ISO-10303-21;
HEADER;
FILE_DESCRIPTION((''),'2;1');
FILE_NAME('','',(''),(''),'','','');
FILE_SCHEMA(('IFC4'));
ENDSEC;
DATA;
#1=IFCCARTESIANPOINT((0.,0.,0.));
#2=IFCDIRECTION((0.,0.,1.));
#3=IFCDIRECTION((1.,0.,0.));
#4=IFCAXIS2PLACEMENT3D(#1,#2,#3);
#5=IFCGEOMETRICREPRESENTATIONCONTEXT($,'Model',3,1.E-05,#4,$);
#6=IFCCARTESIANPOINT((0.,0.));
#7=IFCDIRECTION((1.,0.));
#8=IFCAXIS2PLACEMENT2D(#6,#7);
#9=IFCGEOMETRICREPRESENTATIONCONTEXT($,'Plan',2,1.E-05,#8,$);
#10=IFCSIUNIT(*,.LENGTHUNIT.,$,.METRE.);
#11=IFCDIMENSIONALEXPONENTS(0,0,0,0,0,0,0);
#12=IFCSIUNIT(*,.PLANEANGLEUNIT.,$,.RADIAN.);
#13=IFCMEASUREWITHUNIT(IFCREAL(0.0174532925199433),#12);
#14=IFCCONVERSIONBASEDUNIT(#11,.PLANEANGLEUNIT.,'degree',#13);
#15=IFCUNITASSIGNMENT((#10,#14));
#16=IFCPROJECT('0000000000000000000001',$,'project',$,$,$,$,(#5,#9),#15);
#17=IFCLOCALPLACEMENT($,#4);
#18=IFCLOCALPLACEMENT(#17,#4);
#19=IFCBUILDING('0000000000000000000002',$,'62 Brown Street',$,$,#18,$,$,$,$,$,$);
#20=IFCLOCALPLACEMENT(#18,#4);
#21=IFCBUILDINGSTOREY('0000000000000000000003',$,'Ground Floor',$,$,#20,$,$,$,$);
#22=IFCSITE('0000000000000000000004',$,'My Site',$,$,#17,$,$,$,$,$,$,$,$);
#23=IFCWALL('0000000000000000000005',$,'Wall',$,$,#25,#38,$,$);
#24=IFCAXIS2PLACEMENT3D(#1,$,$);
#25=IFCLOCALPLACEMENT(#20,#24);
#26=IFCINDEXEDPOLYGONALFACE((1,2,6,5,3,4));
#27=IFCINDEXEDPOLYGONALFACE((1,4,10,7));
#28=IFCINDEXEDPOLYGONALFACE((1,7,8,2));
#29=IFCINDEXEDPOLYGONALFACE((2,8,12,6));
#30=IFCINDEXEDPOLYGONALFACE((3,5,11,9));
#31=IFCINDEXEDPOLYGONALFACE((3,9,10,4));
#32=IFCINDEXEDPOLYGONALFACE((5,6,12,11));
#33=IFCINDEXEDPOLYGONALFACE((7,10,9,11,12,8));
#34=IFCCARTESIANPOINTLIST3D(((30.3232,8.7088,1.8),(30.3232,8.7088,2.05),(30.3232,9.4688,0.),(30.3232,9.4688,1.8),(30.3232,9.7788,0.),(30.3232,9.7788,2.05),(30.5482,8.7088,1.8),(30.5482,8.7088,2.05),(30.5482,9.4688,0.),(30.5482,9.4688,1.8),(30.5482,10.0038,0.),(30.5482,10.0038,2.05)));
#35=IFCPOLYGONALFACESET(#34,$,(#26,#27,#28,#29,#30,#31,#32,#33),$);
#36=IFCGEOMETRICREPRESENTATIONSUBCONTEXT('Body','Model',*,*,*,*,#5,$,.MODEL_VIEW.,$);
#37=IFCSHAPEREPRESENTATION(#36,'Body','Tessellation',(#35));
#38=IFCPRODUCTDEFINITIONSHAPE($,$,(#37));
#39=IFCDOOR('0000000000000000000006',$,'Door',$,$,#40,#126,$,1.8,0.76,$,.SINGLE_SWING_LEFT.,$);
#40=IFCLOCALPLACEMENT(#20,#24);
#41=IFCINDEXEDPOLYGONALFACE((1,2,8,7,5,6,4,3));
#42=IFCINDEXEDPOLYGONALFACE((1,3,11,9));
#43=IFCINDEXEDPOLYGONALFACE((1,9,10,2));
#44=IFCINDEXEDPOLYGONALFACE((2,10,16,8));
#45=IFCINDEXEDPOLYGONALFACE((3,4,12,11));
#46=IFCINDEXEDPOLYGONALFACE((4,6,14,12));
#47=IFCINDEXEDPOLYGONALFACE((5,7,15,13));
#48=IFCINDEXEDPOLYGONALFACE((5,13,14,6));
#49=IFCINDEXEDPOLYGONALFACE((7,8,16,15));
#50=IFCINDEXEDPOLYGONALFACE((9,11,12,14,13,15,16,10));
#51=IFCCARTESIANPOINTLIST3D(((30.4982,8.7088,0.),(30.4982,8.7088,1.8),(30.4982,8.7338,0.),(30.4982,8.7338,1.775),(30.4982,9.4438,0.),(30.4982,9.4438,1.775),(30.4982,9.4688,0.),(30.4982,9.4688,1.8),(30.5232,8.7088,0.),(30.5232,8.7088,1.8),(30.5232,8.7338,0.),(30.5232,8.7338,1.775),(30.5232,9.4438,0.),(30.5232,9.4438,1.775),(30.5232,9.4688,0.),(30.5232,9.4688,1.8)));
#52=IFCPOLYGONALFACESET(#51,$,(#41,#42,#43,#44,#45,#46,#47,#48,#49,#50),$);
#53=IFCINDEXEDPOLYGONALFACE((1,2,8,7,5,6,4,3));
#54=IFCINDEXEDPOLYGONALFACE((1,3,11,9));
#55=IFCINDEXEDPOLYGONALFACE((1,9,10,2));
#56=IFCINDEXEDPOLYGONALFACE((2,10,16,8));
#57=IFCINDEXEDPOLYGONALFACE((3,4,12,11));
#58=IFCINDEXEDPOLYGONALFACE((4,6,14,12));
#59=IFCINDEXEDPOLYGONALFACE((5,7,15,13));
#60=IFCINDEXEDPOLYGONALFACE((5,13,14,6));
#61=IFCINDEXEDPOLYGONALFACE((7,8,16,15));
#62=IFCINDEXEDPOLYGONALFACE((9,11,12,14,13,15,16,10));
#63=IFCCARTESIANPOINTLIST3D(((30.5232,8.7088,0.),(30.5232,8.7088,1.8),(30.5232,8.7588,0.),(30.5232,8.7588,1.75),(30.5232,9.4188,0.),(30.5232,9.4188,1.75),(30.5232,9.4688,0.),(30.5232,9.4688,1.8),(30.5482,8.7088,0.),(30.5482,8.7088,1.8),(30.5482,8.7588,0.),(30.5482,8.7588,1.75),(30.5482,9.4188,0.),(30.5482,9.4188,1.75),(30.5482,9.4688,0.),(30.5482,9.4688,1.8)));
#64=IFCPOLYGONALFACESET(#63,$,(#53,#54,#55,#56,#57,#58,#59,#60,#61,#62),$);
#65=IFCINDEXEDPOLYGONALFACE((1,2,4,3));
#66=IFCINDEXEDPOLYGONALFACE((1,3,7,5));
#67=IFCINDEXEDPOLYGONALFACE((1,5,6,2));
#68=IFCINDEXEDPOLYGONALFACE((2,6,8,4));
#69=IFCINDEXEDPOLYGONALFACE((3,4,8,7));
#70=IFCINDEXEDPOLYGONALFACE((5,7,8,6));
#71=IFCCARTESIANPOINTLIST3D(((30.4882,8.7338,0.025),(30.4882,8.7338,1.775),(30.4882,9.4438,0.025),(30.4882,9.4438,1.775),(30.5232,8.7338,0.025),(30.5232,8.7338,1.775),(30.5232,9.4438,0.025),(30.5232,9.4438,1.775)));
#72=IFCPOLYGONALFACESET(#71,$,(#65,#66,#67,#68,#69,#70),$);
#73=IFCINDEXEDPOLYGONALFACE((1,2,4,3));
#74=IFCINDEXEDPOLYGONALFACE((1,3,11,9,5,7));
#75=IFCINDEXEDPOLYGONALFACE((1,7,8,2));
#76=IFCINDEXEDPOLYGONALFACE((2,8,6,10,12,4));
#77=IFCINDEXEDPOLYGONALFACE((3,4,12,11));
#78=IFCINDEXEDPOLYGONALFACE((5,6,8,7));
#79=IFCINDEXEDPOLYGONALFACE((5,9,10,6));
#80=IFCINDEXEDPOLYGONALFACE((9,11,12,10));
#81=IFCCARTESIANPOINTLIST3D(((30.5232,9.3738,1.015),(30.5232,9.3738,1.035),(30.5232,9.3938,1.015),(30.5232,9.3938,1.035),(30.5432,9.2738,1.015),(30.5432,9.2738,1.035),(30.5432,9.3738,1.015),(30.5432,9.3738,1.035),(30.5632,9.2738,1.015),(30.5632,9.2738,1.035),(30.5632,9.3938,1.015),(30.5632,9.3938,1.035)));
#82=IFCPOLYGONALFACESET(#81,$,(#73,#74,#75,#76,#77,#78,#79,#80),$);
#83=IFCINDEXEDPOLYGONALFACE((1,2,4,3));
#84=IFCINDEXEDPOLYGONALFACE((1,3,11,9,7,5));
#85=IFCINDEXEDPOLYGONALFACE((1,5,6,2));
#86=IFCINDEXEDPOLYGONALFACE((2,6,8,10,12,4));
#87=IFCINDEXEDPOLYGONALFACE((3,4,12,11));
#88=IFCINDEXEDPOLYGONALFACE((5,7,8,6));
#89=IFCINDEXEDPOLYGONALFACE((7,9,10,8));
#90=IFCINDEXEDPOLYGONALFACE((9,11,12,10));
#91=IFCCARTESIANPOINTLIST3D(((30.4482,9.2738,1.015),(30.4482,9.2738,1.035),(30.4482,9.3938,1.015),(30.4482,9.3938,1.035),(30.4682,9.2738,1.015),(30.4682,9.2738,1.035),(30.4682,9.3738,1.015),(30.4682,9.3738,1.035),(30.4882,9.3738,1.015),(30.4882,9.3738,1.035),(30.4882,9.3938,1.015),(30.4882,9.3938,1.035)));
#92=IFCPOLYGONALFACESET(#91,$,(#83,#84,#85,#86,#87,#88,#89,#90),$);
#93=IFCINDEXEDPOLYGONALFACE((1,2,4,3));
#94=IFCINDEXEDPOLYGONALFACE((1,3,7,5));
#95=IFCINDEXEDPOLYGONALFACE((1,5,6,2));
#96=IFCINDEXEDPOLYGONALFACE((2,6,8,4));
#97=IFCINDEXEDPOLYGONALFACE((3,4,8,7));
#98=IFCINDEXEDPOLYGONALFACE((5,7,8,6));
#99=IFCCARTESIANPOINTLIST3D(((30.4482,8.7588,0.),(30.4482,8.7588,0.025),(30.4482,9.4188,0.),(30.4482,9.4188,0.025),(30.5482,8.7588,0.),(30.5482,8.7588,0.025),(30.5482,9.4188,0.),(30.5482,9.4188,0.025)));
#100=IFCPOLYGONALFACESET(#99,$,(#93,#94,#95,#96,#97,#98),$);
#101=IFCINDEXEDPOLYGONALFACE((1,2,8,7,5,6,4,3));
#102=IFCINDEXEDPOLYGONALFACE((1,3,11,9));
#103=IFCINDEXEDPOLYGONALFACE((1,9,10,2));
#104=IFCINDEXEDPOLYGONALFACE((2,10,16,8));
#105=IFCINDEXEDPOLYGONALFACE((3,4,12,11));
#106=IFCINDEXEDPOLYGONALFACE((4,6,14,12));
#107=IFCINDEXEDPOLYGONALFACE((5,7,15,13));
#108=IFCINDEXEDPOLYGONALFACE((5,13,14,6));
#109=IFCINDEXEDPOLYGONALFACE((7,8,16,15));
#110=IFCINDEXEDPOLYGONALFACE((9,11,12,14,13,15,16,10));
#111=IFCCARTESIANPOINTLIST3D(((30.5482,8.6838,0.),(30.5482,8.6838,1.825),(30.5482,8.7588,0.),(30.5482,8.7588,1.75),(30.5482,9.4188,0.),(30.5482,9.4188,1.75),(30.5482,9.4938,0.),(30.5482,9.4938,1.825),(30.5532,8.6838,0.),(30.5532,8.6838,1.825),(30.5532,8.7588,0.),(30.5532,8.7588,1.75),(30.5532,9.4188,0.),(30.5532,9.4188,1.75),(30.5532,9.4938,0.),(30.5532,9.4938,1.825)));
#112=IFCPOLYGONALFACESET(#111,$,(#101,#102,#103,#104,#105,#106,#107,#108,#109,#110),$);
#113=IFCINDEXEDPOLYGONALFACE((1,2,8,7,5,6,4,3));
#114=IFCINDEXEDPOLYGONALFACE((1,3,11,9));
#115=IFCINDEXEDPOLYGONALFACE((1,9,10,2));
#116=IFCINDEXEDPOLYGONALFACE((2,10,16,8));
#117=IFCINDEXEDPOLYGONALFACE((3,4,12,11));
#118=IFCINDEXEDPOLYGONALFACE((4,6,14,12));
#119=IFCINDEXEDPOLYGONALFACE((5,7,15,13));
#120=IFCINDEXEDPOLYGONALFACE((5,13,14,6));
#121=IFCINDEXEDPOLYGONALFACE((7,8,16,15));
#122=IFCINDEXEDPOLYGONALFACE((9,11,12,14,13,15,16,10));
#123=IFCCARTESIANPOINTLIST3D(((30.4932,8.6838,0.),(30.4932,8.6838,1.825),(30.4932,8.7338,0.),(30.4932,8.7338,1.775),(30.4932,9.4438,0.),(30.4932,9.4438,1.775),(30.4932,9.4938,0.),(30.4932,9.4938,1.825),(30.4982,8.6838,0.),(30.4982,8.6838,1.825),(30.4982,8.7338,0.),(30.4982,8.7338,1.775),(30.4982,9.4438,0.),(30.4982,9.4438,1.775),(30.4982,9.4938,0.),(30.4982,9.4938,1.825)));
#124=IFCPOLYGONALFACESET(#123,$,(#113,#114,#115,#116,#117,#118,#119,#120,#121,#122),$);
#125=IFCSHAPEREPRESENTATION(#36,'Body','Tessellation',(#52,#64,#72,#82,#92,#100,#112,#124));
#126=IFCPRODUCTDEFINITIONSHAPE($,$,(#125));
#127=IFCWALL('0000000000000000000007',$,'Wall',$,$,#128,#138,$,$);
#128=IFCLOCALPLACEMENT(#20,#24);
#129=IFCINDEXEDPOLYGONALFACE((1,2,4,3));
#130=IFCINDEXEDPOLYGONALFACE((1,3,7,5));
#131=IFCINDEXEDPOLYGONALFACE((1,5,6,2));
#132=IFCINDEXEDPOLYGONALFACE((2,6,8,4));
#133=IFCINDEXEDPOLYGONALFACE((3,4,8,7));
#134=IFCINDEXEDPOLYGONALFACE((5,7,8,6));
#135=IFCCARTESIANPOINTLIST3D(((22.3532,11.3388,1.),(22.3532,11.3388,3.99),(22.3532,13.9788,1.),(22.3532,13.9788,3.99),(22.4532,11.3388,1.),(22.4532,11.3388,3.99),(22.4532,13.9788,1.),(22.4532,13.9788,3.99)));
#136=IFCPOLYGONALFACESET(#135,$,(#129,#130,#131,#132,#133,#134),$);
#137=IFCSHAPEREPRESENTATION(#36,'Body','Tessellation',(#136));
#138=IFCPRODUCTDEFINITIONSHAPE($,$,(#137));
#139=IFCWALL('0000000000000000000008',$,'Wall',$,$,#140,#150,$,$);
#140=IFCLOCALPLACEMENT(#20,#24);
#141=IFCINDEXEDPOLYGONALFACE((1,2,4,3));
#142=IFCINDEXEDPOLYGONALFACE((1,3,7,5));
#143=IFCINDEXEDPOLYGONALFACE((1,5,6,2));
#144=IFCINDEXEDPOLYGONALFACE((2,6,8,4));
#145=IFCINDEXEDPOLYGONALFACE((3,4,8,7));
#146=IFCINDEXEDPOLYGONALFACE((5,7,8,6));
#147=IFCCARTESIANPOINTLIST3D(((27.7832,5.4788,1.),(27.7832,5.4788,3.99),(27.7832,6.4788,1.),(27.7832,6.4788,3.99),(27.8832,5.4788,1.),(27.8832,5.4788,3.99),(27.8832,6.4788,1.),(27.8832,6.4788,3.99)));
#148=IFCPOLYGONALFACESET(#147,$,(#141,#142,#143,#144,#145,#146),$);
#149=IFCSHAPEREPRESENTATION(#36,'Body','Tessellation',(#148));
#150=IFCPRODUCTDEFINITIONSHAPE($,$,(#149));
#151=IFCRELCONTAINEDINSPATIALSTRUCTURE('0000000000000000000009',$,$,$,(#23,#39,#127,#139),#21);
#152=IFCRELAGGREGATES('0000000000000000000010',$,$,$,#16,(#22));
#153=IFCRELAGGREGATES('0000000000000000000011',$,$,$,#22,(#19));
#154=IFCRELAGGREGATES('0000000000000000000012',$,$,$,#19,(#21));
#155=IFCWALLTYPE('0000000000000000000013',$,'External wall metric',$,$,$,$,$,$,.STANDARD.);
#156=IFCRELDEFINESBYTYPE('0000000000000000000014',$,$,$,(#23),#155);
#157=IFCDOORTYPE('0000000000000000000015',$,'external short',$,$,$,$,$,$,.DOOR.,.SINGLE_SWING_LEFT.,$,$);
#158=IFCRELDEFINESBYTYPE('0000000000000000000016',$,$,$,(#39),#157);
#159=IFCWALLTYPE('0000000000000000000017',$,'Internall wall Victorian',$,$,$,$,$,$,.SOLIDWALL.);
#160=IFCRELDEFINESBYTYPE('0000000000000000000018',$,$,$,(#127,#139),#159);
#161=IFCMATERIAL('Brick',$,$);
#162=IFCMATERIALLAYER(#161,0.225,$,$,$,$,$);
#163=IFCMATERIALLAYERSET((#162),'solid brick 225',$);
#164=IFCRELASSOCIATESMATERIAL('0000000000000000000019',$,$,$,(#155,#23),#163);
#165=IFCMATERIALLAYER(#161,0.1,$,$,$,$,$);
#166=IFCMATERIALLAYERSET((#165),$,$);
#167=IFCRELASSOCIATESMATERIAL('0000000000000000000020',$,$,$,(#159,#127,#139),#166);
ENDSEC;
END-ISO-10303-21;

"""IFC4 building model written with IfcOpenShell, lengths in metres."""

from ifc_helpers import new_model, entity, si_unit, converted_unit, frame, origin_with_axes, origin_2d_with_axis, place, context, subcontext, project, spatial, line, indexed_curve, outline, extrude, clip, halfspace, shape, source, transform, mapped, material, layer, layer_set, layer_usage, type_object, type_shapes, element, fill, save


model = new_model("IFC4")

# Units and contexts
model_context = context("Model", 3, precision=1e-05, world=origin_with_axes())
plan_context = context("Plan", 2, precision=1e-05, world=origin_2d_with_axis())
body_context_1 = subcontext(model_context, "Body", "Model", "MODEL_VIEW")
body_context_2 = subcontext(plan_context, "Body", "Plan", "PLAN_VIEW")
ifc_project = project(units=[si_unit("LENGTHUNIT", "METRE"), converted_unit("PLANEANGLEUNIT", "degree", entity("IfcReal", 0.0174532925199433), si_unit("PLANEANGLEUNIT", "RADIAN"), dimensions=[0, 0, 0, 0, 0, 0, 0])], contexts=[model_context, plan_context])

# Site, building, storey
site_placement = place(None, origin_with_axes())
site = spatial("IfcSite", under=ifc_project, at=site_placement, Name="My Site")
building_placement = place(site_placement, origin_with_axes())
building = spatial("IfcBuilding", under=site, at=building_placement, Name="62 Brown Street")
storey_placement = place(building_placement, origin_with_axes())
storey = spatial("IfcBuildingStorey", under=building, at=storey_placement, Name="Ground Floor")

# Shared definitions
ifc_material_1 = material(Name="Brick")

# Shared definitions
ifc_layer_1 = layer(ifc_material_1, 0.225)
ifc_layer_set_1 = layer_set([ifc_layer_1], Name="solid brick 225")
wall_type_1 = type_object("IfcWallType", Name="External wall metric", PredefinedType="STANDARD", material=ifc_layer_set_1)

# Wall, opening, door
ifc_layer_usage_1 = layer_usage(ifc_layer_set_1, "AXIS2", "POSITIVE", 0.0)
wall_1_placement = place(storey_placement, frame((30.5482, 8.7088, 0.0), z_axis=(0.0, 0.0, 1.0), x_axis=(0.0, 1.0, 0.0)))
wall_1 = element("IfcWall", 1, at=wall_1_placement, inside=storey, type_object=wall_type_1, material=ifc_layer_usage_1, Name="Wall", context=body_context_1, shape_type="Clipping", body=[
    clip(extrude(outline(indexed_curve([(0.0, 0.0), (0.0, 0.225), (1.295, 0.225), (1.295, 0.0), (0.0, 0.0)], self_intersect=False)), origin_with_axes(), (0.0, 0.0, 1.0), 2.05), halfspace(frame((1.295, 0.0, 0.0), z_axis=(0.450001, 0.450001, 0.0), x_axis=(-0.225, 0.225, 0.0)), False)),
])
shared_shape_1 = source(origin_with_axes(), body_context_1, "Body", "SweptSolid", [
    extrude(outline(indexed_curve([(0.0, 0.0), (0.76, 0.0), (0.76, 1.8), (0.0, 1.8)], segments=[line(1, 2, 3, 4, 1)])), frame((0.0, -0.1, 0.0), z_axis=(0.0, -1.0, 0.0), x_axis=(1.0, 0.0, 0.0)), (0.0, 0.0, -1.0), 0.425),
])
opening_placement = place(wall_1_placement, frame((0.0, 0.0, 0.0), z_axis=(0.0, 0.0, 1.0), x_axis=(1.0, 0.0, 0.0)))
opening = element("IfcOpeningElement", 2, at=opening_placement, cuts=wall_1, PredefinedType="OPENING", context=body_context_1, shape_type="MappedRepresentation", body=[
    mapped(shared_shape_1, transform((0.0, 0.0, 0.0), x_axis=(1.0, 0.0, 0.0), y_axis=(0.0, 1.0, 0.0), z_axis=(0.0, 0.0, 1.0), scale=1.0)),
])
door_type = type_object("IfcDoorType", Name="external short", OperationType="SINGLE_SWING_LEFT", PredefinedType="DOOR")
shared_shape_2 = source(origin_with_axes(), body_context_1, "Body", "SweptSolid", [
    extrude(outline(indexed_curve([(0.0, 0.0), (0.0, 1.8), (0.76, 1.8), (0.76, 0.0), (0.735, 0.0), (0.735, 1.775), (0.025, 1.775), (0.025, 0.0)], segments=[line(1, 2, 3, 4, 5, 6, 7, 8, 1)])), frame((0.0, 0.025, 0.0), z_axis=(0.0, -1.0, 0.0), x_axis=(1.0, 0.0, 0.0)), (0.0, 0.0, -1.0), 0.025),
    extrude(outline(indexed_curve([(0.0, 0.0), (0.0, 1.8), (0.76, 1.8), (0.76, 0.0), (0.71, 0.0), (0.71, 1.75), (0.05, 1.75), (0.05, 0.0)], segments=[line(1, 2, 3, 4, 5, 6, 7, 8, 1)])), frame((0.0, 0.0, 0.0), z_axis=(0.0, -1.0, 0.0), x_axis=(1.0, 0.0, 0.0)), (0.0, 0.0, -1.0), 0.025),
    extrude(outline(indexed_curve([(0.0, 0.0), (0.71, 0.0), (0.71, 0.035), (0.0, 0.035)], segments=[line(1, 2, 3, 4, 1)])), frame((0.025, 0.025, 0.025), z_axis=(0.0, 0.0, 1.0), x_axis=(1.0, 0.0, 0.0)), (0.0, 0.0, 1.0), 1.75),
    extrude(outline(indexed_curve([(0.0, 0.0), (0.0, -0.04), (-0.12, -0.04), (-0.12, -0.02), (-0.02, -0.02), (-0.02, 0.0)], segments=[line(1, 2, 3, 4, 5, 6, 1)])), frame((0.685, 0.025, 1.015), z_axis=(0.0, 0.0, 1.0), x_axis=(1.0, 0.0, 0.0)), (0.0, 0.0, 1.0), 0.02),
    extrude(outline(indexed_curve([(0.0, 0.0), (0.0, 0.04), (-0.12, 0.04), (-0.12, 0.02), (-0.02, 0.02), (-0.02, 0.0)], segments=[line(1, 2, 3, 4, 5, 6, 1)])), frame((0.685, 0.06, 1.015), z_axis=(0.0, 0.0, 1.0), x_axis=(1.0, 0.0, 0.0)), (0.0, 0.0, 1.0), 0.02),
    extrude(outline(indexed_curve([(0.0, 0.0), (0.66, 0.0), (0.66, 0.1), (0.0, 0.1)], segments=[line(1, 2, 3, 4, 1)])), frame((0.05, 0.0, 0.0), z_axis=(0.0, 0.0, 1.0), x_axis=(1.0, 0.0, 0.0)), (0.0, 0.0, 1.0), 0.025),
    extrude(outline(indexed_curve([(0.0, 0.0), (0.0, 1.825), (0.81, 1.825), (0.81, 0.0), (0.735, 0.0), (0.735, 1.75), (0.075, 1.75), (0.075, 0.0)], segments=[line(1, 2, 3, 4, 5, 6, 7, 8, 1)])), frame((-0.025, -0.005, 0.0), z_axis=(0.0, -1.0, 0.0), x_axis=(1.0, 0.0, 0.0)), (0.0, 0.0, -1.0), 0.005),
    extrude(outline(indexed_curve([(0.0, 0.0), (0.0, 1.825), (0.81, 1.825), (0.81, 0.0), (0.76, 0.0), (0.76, 1.775), (0.05, 1.775), (0.05, 0.0)], segments=[line(1, 2, 3, 4, 5, 6, 7, 8, 1)])), frame((-0.025, 0.05, 0.0), z_axis=(0.0, -1.0, 0.0), x_axis=(1.0, 0.0, 0.0)), (0.0, 0.0, -1.0), 0.005),
])
shared_shape_3 = source(origin_with_axes(), body_context_2, "Body", "Curve2D", [
    entity("IfcIndexedPolyCurve", entity("IfcCartesianPointList2D", [[0.0, 0.0], [0.0, 0.05], [0.025, 0.05], [0.025, 0.025], [0.05, 0.025], [0.05, 0.0]]), [entity("IfcLineIndex", [1, 2, 3, 4, 5, 6, 1])]),
    entity("IfcIndexedPolyCurve", entity("IfcCartesianPointList2D", [[0.76, 0.0], [0.76, 0.05], [0.735, 0.05], [0.735, 0.025], [0.71, 0.025], [0.71, 0.0]]), [entity("IfcLineIndex", [1, 2, 3, 4, 5, 6, 1])]),
    entity("IfcTrimmedCurve", entity("IfcEllipse", entity("IfcAxis2Placement2D", entity("IfcCartesianPoint", [0.06, 0.05]), entity("IfcDirection", [1.0, 0.0])), 0.675, 0.71), [entity("IfcCartesianPoint", [0.735, 0.05])], [entity("IfcCartesianPoint", [0.06, 0.76])], True, "CARTESIAN"),
    entity("IfcIndexedPolyCurve", entity("IfcCartesianPointList2D", [[0.025, 0.05], [0.06, 0.05], [0.06, 0.76], [0.025, 0.76]]), [entity("IfcLineIndex", [1, 2, 3, 4, 1])]),
])
type_shapes(door_type, [shared_shape_2, shared_shape_3])
door_placement = place(opening_placement, frame((0.0, 0.0, 0.0), z_axis=(0.0, 0.0, 1.0), x_axis=(1.0, 0.0, 0.0)))
door = element("IfcDoor", 3, at=door_placement, inside=storey, type_object=door_type, Name="Door", OperationType="SINGLE_SWING_LEFT", OverallHeight=1.8, OverallWidth=0.76, shapes=[
    shape(body_context_1, "Body", "MappedRepresentation", [mapped(shared_shape_2, transform((0.0, 0.0, 0.0), x_axis=(1.0, 0.0, 0.0), y_axis=(0.0, 1.0, 0.0), z_axis=(0.0, 0.0, 1.0), scale=1.0))]),
    shape(body_context_2, "Body", "MappedRepresentation", [mapped(shared_shape_3, transform((0.0, 0.0, 0.0), x_axis=(1.0, 0.0, 0.0), y_axis=(0.0, 1.0, 0.0), z_axis=(0.0, 0.0, 1.0), scale=1.0))]),
])
fill(opening, door)

# Walls
ifc_layer_2 = layer(ifc_material_1, 0.1)
ifc_layer_set_2 = layer_set([ifc_layer_2])
ifc_layer_usage_2 = layer_usage(ifc_layer_set_2, "AXIS2", "POSITIVE", 0.0)
wall_type_2 = type_object("IfcWallType", Name="Internall wall Victorian", PredefinedType="SOLIDWALL", material=ifc_layer_set_2)
wall_2_placement = place(storey_placement, frame((22.4532, 11.3388, 1.0), z_axis=(0.0, 0.0, 1.0), x_axis=(0.0, 1.0, 0.0)))
element("IfcWall", 4, at=wall_2_placement, inside=storey, type_object=wall_type_2, material=ifc_layer_usage_2, Name="Wall", context=body_context_1, shape_type="SweptSolid", body=[
    extrude(outline(indexed_curve([(0.0, 0.0), (0.0, 0.1), (2.64, 0.1), (2.64, 0.0), (0.0, 0.0)], self_intersect=False)), origin_with_axes(), (0.0, 0.0, 1.0), 2.99),
])
ifc_layer_usage_3 = layer_usage(ifc_layer_set_2, "AXIS2", "POSITIVE", 0.0)
wall_3_placement = place(storey_placement, frame((27.8832, 5.4788, 1.0), z_axis=(0.0, 0.0, 1.0), x_axis=(0.0, 1.0, 0.0)))
element("IfcWall", 5, at=wall_3_placement, inside=storey, type_object=wall_type_2, material=ifc_layer_usage_3, Name="Wall", context=body_context_1, shape_type="SweptSolid", body=[
    extrude(outline(indexed_curve([(0.0, 0.0), (0.0, 0.1), (1.0, 0.1), (1.0, 0.0), (0.0, 0.0)], self_intersect=False)), origin_with_axes(), (0.0, 0.0, 1.0), 2.99),
])

save(model, "model.ifc")
